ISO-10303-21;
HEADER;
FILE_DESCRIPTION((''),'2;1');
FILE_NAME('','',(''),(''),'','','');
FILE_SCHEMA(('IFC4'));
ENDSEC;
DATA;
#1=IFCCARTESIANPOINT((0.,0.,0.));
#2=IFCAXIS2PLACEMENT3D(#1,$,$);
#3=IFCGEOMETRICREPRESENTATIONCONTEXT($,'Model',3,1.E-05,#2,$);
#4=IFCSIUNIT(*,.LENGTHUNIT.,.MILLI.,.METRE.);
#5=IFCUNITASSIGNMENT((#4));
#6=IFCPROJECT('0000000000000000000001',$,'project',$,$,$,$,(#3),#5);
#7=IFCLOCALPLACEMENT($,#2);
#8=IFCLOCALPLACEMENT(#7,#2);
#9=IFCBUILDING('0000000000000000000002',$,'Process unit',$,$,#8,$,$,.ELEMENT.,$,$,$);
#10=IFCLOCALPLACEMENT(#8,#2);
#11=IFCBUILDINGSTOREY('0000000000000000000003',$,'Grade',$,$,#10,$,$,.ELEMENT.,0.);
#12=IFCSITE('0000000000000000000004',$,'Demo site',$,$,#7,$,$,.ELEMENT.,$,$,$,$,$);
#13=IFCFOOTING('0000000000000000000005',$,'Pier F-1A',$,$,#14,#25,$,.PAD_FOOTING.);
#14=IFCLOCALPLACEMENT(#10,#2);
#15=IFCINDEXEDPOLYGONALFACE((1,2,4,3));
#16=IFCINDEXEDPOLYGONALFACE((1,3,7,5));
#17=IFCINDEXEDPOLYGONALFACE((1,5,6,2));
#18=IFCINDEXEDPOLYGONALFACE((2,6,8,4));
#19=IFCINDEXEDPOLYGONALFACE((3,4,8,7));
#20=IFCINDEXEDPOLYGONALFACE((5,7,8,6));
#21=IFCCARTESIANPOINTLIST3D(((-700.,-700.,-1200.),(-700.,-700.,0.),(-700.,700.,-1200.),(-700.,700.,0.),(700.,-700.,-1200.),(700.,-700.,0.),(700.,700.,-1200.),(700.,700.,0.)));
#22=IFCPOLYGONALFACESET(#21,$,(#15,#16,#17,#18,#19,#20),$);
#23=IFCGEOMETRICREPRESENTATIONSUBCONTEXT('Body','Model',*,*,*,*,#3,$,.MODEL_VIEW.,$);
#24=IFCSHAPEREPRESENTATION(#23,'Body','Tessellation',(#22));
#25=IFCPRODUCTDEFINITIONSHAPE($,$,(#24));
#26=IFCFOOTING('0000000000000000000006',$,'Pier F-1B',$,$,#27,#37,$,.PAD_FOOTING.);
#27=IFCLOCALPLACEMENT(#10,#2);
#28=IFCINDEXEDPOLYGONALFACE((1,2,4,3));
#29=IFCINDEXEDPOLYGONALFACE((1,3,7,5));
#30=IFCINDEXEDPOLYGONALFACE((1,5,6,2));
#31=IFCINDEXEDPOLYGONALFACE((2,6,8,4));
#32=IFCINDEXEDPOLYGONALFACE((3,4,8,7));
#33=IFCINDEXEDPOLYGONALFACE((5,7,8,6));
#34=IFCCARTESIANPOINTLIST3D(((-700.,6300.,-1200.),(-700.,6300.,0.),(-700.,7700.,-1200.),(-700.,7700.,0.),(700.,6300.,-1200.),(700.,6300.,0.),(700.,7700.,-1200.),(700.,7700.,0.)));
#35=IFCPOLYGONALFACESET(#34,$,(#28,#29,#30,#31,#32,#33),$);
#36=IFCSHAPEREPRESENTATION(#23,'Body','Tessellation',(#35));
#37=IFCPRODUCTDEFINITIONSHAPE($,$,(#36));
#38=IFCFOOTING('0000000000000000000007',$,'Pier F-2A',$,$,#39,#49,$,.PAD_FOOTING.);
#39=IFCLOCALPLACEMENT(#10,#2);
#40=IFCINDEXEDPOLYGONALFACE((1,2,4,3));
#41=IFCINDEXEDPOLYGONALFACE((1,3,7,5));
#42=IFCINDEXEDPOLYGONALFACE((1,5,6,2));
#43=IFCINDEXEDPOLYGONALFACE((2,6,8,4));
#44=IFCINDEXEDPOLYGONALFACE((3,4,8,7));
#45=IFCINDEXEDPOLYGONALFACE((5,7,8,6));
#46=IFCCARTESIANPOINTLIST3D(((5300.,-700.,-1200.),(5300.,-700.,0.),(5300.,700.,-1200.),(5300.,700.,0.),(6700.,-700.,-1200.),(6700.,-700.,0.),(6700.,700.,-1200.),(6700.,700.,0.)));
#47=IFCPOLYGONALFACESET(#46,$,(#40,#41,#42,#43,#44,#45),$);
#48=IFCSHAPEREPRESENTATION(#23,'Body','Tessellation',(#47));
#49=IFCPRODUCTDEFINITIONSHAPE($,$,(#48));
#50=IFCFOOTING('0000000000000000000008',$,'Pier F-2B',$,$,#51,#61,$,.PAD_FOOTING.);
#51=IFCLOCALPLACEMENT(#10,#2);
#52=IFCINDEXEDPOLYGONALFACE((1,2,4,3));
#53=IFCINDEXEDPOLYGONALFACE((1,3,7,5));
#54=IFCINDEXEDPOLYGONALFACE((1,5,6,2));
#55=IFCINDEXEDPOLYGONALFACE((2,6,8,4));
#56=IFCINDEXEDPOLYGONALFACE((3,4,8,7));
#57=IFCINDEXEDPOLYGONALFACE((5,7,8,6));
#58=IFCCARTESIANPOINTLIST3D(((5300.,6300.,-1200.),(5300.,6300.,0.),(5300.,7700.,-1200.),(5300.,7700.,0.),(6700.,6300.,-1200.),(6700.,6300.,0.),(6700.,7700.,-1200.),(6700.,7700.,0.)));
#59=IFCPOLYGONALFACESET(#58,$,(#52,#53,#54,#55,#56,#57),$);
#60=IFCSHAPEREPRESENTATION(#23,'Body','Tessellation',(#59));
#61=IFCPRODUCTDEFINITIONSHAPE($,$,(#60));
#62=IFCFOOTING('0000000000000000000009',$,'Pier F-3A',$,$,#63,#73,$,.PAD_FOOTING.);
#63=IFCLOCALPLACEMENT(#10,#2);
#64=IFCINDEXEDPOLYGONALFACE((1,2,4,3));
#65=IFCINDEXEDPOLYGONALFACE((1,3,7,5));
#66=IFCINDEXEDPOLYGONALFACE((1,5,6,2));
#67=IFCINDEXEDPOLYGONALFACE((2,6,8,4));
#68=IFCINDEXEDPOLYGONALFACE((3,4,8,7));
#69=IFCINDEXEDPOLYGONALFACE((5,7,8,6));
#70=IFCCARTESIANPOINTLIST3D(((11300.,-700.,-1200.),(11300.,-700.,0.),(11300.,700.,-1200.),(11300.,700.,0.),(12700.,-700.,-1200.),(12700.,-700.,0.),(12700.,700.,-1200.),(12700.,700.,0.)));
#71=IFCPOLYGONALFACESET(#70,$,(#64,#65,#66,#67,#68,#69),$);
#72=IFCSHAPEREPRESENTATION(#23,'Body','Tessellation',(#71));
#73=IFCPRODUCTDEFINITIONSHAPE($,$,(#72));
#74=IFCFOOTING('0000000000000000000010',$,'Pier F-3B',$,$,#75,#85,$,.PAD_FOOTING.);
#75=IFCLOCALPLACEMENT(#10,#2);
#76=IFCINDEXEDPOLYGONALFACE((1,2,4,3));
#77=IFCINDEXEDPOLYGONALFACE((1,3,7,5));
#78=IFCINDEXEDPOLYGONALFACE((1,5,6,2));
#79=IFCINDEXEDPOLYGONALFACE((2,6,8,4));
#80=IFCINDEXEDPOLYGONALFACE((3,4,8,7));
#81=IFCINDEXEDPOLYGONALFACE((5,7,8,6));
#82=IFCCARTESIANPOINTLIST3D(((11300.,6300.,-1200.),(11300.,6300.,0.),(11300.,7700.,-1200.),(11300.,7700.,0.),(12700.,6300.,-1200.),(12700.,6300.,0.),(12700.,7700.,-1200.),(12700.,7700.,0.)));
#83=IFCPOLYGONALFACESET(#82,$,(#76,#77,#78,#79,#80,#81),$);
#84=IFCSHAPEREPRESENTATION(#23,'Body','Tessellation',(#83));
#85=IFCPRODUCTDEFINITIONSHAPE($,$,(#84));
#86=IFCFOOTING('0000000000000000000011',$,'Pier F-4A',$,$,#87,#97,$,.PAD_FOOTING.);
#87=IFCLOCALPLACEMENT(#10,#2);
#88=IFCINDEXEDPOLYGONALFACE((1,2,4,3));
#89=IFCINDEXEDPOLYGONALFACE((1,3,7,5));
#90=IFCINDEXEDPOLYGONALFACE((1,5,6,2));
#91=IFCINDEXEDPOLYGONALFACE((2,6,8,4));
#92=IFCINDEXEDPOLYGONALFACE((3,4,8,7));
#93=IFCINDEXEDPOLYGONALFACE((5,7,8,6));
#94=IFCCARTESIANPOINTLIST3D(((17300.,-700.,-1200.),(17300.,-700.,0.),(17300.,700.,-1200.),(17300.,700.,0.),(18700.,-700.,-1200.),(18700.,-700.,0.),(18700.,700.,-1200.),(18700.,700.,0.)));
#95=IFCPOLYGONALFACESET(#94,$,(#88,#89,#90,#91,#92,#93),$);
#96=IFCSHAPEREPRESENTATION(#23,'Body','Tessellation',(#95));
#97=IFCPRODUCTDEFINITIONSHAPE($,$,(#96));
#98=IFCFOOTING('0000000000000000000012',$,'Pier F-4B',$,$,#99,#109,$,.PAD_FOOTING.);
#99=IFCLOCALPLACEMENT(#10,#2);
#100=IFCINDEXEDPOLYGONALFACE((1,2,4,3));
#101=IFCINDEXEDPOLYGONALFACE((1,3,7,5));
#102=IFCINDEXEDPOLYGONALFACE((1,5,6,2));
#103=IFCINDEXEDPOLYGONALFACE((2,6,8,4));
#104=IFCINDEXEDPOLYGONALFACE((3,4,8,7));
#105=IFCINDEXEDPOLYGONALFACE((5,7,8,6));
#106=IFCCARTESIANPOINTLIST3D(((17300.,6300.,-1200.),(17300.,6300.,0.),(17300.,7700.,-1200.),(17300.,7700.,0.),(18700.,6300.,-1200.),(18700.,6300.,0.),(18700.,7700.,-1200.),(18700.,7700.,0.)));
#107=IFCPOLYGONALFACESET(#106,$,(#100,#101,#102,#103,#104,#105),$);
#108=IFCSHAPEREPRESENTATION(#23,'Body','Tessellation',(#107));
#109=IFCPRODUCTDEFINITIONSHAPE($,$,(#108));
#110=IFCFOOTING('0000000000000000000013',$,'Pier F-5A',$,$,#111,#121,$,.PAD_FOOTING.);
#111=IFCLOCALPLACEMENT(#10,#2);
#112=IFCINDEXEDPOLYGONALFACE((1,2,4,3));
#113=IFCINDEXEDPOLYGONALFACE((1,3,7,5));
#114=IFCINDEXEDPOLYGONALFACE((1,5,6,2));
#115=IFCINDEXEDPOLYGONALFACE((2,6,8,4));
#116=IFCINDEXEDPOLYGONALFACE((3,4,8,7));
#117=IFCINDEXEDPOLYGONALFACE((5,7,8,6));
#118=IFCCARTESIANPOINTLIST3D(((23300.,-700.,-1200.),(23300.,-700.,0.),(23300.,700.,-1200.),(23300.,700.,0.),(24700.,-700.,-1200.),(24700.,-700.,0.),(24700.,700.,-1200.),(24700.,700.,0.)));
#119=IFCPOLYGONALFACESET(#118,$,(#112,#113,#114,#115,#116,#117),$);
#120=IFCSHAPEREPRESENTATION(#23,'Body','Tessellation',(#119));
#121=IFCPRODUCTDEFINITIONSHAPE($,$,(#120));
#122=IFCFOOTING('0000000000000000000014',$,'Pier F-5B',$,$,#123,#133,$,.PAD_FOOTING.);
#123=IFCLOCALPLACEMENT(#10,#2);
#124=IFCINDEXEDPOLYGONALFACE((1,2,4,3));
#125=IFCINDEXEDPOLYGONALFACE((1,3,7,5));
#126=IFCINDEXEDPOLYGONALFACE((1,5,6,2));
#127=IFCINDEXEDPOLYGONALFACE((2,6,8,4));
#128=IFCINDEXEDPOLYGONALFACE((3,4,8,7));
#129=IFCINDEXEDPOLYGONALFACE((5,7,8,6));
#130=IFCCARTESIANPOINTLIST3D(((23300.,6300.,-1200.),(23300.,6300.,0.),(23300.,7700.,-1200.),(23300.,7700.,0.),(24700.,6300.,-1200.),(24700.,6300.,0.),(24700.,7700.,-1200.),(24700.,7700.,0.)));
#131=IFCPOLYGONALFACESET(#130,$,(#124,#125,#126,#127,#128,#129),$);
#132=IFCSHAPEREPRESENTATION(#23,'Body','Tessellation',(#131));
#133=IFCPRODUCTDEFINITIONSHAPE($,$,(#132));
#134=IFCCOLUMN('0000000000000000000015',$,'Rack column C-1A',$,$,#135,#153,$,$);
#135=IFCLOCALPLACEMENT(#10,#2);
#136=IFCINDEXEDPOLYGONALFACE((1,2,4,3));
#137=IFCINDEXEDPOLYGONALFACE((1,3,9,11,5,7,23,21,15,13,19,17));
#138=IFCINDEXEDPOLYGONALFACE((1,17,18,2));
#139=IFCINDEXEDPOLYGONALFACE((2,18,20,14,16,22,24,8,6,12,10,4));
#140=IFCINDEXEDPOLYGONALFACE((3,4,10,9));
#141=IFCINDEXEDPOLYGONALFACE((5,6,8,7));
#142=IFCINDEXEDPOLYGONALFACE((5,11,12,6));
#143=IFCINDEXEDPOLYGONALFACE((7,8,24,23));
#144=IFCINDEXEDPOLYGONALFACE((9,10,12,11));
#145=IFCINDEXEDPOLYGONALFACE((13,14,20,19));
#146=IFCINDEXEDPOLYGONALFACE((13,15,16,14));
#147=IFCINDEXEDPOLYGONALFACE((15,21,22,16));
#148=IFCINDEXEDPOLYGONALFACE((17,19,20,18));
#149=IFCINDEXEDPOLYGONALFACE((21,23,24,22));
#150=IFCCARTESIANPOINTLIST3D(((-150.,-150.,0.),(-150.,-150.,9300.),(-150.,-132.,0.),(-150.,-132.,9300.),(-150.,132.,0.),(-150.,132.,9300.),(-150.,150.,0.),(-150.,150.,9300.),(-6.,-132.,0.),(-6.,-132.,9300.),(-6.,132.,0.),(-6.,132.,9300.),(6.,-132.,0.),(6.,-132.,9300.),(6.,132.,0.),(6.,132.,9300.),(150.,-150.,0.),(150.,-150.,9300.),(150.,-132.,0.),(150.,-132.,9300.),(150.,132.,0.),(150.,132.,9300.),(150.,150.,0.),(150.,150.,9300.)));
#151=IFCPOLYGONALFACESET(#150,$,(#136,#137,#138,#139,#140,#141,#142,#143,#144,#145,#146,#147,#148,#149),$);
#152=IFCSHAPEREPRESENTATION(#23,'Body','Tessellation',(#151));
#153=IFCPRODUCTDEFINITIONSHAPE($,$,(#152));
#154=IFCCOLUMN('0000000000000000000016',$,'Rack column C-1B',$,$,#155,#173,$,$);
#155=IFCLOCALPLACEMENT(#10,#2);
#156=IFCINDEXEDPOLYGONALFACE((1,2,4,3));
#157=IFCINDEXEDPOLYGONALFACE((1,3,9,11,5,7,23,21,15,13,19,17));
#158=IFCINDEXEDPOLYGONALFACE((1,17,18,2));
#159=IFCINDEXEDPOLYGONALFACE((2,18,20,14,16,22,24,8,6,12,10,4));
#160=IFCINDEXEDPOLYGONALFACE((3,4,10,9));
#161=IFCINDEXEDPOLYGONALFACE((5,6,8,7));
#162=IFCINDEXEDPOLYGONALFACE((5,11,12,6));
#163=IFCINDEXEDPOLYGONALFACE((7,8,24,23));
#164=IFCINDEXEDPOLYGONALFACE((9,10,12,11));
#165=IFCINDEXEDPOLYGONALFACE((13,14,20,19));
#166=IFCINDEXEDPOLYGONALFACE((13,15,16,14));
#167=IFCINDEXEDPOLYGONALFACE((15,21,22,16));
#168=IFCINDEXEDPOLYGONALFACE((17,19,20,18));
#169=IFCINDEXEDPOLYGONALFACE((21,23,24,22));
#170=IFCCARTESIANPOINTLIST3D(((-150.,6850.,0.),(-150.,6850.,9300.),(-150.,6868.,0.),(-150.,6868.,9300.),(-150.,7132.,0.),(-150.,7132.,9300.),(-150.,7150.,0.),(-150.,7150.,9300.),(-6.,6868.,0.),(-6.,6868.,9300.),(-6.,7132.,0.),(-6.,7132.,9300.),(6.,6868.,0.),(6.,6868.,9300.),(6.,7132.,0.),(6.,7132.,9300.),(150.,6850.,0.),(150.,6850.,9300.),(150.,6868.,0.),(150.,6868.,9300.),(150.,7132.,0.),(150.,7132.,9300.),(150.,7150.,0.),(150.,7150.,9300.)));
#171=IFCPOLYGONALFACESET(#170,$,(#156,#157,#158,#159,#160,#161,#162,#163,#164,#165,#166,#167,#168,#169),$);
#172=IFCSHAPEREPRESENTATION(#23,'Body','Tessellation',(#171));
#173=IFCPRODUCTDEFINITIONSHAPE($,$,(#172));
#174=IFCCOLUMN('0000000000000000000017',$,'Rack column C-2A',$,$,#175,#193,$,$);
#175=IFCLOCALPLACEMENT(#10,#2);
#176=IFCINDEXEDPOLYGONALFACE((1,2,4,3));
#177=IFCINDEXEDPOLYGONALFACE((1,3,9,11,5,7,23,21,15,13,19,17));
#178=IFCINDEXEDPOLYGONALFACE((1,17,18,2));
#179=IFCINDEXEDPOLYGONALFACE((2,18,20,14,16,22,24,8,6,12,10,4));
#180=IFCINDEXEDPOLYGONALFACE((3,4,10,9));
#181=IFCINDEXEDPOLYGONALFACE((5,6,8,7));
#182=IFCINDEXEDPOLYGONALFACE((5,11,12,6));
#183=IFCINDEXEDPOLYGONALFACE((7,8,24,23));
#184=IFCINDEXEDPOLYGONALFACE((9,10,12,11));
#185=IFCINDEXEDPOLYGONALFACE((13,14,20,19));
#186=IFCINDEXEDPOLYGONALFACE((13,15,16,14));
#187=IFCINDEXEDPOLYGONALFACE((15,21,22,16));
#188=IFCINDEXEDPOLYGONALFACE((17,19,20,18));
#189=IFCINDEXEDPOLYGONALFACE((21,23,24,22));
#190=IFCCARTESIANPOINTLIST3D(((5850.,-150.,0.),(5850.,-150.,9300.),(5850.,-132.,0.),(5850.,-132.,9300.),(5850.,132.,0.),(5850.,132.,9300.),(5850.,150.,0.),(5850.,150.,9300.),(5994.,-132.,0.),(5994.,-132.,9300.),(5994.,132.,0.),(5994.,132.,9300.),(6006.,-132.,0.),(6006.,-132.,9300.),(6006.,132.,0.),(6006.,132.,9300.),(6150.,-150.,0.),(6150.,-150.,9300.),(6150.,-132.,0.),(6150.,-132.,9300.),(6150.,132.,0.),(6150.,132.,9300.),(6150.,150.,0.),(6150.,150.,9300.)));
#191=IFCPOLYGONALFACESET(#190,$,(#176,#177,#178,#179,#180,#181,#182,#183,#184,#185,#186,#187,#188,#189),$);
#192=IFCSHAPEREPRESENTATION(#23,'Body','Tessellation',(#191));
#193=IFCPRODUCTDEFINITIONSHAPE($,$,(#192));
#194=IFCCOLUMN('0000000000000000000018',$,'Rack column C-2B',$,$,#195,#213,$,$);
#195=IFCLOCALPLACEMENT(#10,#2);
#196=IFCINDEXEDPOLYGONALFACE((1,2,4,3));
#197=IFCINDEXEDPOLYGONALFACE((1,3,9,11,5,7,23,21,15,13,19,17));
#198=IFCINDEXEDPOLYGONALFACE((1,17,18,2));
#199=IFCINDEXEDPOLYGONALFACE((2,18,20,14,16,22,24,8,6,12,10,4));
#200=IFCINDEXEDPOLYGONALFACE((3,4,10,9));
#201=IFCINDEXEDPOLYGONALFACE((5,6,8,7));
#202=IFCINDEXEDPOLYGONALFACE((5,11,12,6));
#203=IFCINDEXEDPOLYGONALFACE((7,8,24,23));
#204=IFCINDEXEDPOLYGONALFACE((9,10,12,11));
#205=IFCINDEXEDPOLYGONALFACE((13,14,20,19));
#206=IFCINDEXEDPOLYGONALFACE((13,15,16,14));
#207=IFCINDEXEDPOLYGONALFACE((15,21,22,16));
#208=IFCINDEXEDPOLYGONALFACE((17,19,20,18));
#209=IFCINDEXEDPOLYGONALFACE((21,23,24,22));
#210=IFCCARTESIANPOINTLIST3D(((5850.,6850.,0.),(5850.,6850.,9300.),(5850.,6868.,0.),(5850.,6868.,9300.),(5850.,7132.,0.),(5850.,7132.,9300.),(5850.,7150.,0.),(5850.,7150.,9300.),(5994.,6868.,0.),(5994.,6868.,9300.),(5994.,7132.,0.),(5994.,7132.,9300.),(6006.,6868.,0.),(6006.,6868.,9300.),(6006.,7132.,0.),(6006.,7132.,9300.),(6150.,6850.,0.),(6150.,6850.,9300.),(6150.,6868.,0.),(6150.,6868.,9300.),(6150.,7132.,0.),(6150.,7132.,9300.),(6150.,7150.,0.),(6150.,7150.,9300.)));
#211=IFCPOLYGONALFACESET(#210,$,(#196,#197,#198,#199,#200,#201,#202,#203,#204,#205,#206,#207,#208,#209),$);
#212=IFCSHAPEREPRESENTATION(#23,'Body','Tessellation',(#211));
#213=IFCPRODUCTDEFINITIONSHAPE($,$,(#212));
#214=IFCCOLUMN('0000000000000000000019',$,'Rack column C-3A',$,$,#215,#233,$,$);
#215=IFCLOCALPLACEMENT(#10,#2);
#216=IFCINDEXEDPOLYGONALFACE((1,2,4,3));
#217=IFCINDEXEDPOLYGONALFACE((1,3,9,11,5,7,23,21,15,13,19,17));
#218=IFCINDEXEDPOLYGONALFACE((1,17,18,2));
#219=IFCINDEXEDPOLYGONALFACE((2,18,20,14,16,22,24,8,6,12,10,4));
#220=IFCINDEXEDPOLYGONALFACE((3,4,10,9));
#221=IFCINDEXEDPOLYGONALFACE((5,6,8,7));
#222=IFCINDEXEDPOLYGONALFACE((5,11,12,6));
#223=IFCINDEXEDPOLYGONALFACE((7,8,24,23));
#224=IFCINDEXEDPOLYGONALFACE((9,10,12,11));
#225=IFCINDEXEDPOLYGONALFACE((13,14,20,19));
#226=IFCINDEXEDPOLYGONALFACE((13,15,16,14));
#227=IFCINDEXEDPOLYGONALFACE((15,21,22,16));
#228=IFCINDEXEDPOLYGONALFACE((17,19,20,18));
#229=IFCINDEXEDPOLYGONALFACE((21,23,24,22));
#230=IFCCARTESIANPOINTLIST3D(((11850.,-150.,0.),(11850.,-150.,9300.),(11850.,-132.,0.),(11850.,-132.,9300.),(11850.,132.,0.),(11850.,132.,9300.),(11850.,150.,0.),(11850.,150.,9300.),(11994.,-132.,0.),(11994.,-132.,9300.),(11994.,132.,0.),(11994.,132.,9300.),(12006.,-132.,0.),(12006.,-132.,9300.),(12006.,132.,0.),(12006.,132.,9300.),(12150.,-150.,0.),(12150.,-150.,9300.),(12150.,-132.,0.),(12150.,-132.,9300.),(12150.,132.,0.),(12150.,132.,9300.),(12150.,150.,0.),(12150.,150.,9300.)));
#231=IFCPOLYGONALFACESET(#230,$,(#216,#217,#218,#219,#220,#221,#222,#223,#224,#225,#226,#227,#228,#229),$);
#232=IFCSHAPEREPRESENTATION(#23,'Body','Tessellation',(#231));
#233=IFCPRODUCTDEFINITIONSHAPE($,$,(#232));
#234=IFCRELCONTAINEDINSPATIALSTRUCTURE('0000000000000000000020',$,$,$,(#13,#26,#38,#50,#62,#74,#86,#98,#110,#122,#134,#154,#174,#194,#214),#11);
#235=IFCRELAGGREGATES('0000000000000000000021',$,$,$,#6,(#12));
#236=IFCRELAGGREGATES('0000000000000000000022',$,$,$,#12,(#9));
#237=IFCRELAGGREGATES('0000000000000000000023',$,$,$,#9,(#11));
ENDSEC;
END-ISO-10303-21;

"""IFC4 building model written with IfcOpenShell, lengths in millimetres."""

from ifc_helpers import new_model, si_unit, frame, origin, place, context, subcontext, project, spatial, rectangle, i_section, extrude, element, save


model = new_model("IFC4")

# Units and contexts
model_context = context("Model", 3, precision=1e-05, world=origin())
body_context = subcontext(model_context, "Body", "Model", "MODEL_VIEW")
ifc_project = project(units=[si_unit("LENGTHUNIT", "METRE", prefix="MILLI")], contexts=[model_context])

# Site, building, storey
site_placement = place(None, origin())
site = spatial("IfcSite", under=ifc_project, at=site_placement, Name="Demo site", CompositionType="ELEMENT")
building_placement = place(site_placement, origin())
building = spatial("IfcBuilding", under=site, at=building_placement, Name="Process unit", CompositionType="ELEMENT")
storey_placement = place(building_placement, origin())
storey = spatial("IfcBuildingStorey", under=building, at=storey_placement, Name="Grade", CompositionType="ELEMENT", Elevation=0.0)

# Footings
for number, where, name in (
    (1, (0.0, 0.0, -1200.0), "Pier F-1A"),
    (2, (0.0, 7000.0, -1200.0), "Pier F-1B"),
    (3, (6000.0, 0.0, -1200.0), "Pier F-2A"),
    (4, (6000.0, 7000.0, -1200.0), "Pier F-2B"),
    (5, (12000.0, 0.0, -1200.0), "Pier F-3A"),
    (6, (12000.0, 7000.0, -1200.0), "Pier F-3B"),
    (7, (18000.0, 0.0, -1200.0), "Pier F-4A"),
    (8, (18000.0, 7000.0, -1200.0), "Pier F-4B"),
    (9, (24000.0, 0.0, -1200.0), "Pier F-5A"),
    (10, (24000.0, 7000.0, -1200.0), "Pier F-5B"),
):
    element("IfcFooting", number, at=place(storey_placement, frame(where)), inside=storey, Name=name, PredefinedType="PAD_FOOTING", context=body_context, shape_type="SweptSolid", body=[
        extrude(rectangle(XDim=1400.0, YDim=1400.0), origin(), (0.0, 0.0, 1.0), 1200.0),
    ])

# Columns
for number, where, name in (
    (11, (0.0, 0.0, 0.0), "Rack column C-1A"),
    (12, (0.0, 7000.0, 0.0), "Rack column C-1B"),
    (13, (6000.0, 0.0, 0.0), "Rack column C-2A"),
    (14, (6000.0, 7000.0, 0.0), "Rack column C-2B"),
    (15, (12000.0, 0.0, 0.0), "Rack column C-3A"),
):
    element("IfcColumn", number, at=place(storey_placement, frame(where)), inside=storey, Name=name, context=body_context, shape_type="SweptSolid", body=[
        extrude(i_section(OverallWidth=300.0, OverallDepth=300.0, WebThickness=12.0, FlangeThickness=18.0), origin(), (0.0, 0.0, 1.0), 9300.0),
    ])

save(model, "model.ifc")
